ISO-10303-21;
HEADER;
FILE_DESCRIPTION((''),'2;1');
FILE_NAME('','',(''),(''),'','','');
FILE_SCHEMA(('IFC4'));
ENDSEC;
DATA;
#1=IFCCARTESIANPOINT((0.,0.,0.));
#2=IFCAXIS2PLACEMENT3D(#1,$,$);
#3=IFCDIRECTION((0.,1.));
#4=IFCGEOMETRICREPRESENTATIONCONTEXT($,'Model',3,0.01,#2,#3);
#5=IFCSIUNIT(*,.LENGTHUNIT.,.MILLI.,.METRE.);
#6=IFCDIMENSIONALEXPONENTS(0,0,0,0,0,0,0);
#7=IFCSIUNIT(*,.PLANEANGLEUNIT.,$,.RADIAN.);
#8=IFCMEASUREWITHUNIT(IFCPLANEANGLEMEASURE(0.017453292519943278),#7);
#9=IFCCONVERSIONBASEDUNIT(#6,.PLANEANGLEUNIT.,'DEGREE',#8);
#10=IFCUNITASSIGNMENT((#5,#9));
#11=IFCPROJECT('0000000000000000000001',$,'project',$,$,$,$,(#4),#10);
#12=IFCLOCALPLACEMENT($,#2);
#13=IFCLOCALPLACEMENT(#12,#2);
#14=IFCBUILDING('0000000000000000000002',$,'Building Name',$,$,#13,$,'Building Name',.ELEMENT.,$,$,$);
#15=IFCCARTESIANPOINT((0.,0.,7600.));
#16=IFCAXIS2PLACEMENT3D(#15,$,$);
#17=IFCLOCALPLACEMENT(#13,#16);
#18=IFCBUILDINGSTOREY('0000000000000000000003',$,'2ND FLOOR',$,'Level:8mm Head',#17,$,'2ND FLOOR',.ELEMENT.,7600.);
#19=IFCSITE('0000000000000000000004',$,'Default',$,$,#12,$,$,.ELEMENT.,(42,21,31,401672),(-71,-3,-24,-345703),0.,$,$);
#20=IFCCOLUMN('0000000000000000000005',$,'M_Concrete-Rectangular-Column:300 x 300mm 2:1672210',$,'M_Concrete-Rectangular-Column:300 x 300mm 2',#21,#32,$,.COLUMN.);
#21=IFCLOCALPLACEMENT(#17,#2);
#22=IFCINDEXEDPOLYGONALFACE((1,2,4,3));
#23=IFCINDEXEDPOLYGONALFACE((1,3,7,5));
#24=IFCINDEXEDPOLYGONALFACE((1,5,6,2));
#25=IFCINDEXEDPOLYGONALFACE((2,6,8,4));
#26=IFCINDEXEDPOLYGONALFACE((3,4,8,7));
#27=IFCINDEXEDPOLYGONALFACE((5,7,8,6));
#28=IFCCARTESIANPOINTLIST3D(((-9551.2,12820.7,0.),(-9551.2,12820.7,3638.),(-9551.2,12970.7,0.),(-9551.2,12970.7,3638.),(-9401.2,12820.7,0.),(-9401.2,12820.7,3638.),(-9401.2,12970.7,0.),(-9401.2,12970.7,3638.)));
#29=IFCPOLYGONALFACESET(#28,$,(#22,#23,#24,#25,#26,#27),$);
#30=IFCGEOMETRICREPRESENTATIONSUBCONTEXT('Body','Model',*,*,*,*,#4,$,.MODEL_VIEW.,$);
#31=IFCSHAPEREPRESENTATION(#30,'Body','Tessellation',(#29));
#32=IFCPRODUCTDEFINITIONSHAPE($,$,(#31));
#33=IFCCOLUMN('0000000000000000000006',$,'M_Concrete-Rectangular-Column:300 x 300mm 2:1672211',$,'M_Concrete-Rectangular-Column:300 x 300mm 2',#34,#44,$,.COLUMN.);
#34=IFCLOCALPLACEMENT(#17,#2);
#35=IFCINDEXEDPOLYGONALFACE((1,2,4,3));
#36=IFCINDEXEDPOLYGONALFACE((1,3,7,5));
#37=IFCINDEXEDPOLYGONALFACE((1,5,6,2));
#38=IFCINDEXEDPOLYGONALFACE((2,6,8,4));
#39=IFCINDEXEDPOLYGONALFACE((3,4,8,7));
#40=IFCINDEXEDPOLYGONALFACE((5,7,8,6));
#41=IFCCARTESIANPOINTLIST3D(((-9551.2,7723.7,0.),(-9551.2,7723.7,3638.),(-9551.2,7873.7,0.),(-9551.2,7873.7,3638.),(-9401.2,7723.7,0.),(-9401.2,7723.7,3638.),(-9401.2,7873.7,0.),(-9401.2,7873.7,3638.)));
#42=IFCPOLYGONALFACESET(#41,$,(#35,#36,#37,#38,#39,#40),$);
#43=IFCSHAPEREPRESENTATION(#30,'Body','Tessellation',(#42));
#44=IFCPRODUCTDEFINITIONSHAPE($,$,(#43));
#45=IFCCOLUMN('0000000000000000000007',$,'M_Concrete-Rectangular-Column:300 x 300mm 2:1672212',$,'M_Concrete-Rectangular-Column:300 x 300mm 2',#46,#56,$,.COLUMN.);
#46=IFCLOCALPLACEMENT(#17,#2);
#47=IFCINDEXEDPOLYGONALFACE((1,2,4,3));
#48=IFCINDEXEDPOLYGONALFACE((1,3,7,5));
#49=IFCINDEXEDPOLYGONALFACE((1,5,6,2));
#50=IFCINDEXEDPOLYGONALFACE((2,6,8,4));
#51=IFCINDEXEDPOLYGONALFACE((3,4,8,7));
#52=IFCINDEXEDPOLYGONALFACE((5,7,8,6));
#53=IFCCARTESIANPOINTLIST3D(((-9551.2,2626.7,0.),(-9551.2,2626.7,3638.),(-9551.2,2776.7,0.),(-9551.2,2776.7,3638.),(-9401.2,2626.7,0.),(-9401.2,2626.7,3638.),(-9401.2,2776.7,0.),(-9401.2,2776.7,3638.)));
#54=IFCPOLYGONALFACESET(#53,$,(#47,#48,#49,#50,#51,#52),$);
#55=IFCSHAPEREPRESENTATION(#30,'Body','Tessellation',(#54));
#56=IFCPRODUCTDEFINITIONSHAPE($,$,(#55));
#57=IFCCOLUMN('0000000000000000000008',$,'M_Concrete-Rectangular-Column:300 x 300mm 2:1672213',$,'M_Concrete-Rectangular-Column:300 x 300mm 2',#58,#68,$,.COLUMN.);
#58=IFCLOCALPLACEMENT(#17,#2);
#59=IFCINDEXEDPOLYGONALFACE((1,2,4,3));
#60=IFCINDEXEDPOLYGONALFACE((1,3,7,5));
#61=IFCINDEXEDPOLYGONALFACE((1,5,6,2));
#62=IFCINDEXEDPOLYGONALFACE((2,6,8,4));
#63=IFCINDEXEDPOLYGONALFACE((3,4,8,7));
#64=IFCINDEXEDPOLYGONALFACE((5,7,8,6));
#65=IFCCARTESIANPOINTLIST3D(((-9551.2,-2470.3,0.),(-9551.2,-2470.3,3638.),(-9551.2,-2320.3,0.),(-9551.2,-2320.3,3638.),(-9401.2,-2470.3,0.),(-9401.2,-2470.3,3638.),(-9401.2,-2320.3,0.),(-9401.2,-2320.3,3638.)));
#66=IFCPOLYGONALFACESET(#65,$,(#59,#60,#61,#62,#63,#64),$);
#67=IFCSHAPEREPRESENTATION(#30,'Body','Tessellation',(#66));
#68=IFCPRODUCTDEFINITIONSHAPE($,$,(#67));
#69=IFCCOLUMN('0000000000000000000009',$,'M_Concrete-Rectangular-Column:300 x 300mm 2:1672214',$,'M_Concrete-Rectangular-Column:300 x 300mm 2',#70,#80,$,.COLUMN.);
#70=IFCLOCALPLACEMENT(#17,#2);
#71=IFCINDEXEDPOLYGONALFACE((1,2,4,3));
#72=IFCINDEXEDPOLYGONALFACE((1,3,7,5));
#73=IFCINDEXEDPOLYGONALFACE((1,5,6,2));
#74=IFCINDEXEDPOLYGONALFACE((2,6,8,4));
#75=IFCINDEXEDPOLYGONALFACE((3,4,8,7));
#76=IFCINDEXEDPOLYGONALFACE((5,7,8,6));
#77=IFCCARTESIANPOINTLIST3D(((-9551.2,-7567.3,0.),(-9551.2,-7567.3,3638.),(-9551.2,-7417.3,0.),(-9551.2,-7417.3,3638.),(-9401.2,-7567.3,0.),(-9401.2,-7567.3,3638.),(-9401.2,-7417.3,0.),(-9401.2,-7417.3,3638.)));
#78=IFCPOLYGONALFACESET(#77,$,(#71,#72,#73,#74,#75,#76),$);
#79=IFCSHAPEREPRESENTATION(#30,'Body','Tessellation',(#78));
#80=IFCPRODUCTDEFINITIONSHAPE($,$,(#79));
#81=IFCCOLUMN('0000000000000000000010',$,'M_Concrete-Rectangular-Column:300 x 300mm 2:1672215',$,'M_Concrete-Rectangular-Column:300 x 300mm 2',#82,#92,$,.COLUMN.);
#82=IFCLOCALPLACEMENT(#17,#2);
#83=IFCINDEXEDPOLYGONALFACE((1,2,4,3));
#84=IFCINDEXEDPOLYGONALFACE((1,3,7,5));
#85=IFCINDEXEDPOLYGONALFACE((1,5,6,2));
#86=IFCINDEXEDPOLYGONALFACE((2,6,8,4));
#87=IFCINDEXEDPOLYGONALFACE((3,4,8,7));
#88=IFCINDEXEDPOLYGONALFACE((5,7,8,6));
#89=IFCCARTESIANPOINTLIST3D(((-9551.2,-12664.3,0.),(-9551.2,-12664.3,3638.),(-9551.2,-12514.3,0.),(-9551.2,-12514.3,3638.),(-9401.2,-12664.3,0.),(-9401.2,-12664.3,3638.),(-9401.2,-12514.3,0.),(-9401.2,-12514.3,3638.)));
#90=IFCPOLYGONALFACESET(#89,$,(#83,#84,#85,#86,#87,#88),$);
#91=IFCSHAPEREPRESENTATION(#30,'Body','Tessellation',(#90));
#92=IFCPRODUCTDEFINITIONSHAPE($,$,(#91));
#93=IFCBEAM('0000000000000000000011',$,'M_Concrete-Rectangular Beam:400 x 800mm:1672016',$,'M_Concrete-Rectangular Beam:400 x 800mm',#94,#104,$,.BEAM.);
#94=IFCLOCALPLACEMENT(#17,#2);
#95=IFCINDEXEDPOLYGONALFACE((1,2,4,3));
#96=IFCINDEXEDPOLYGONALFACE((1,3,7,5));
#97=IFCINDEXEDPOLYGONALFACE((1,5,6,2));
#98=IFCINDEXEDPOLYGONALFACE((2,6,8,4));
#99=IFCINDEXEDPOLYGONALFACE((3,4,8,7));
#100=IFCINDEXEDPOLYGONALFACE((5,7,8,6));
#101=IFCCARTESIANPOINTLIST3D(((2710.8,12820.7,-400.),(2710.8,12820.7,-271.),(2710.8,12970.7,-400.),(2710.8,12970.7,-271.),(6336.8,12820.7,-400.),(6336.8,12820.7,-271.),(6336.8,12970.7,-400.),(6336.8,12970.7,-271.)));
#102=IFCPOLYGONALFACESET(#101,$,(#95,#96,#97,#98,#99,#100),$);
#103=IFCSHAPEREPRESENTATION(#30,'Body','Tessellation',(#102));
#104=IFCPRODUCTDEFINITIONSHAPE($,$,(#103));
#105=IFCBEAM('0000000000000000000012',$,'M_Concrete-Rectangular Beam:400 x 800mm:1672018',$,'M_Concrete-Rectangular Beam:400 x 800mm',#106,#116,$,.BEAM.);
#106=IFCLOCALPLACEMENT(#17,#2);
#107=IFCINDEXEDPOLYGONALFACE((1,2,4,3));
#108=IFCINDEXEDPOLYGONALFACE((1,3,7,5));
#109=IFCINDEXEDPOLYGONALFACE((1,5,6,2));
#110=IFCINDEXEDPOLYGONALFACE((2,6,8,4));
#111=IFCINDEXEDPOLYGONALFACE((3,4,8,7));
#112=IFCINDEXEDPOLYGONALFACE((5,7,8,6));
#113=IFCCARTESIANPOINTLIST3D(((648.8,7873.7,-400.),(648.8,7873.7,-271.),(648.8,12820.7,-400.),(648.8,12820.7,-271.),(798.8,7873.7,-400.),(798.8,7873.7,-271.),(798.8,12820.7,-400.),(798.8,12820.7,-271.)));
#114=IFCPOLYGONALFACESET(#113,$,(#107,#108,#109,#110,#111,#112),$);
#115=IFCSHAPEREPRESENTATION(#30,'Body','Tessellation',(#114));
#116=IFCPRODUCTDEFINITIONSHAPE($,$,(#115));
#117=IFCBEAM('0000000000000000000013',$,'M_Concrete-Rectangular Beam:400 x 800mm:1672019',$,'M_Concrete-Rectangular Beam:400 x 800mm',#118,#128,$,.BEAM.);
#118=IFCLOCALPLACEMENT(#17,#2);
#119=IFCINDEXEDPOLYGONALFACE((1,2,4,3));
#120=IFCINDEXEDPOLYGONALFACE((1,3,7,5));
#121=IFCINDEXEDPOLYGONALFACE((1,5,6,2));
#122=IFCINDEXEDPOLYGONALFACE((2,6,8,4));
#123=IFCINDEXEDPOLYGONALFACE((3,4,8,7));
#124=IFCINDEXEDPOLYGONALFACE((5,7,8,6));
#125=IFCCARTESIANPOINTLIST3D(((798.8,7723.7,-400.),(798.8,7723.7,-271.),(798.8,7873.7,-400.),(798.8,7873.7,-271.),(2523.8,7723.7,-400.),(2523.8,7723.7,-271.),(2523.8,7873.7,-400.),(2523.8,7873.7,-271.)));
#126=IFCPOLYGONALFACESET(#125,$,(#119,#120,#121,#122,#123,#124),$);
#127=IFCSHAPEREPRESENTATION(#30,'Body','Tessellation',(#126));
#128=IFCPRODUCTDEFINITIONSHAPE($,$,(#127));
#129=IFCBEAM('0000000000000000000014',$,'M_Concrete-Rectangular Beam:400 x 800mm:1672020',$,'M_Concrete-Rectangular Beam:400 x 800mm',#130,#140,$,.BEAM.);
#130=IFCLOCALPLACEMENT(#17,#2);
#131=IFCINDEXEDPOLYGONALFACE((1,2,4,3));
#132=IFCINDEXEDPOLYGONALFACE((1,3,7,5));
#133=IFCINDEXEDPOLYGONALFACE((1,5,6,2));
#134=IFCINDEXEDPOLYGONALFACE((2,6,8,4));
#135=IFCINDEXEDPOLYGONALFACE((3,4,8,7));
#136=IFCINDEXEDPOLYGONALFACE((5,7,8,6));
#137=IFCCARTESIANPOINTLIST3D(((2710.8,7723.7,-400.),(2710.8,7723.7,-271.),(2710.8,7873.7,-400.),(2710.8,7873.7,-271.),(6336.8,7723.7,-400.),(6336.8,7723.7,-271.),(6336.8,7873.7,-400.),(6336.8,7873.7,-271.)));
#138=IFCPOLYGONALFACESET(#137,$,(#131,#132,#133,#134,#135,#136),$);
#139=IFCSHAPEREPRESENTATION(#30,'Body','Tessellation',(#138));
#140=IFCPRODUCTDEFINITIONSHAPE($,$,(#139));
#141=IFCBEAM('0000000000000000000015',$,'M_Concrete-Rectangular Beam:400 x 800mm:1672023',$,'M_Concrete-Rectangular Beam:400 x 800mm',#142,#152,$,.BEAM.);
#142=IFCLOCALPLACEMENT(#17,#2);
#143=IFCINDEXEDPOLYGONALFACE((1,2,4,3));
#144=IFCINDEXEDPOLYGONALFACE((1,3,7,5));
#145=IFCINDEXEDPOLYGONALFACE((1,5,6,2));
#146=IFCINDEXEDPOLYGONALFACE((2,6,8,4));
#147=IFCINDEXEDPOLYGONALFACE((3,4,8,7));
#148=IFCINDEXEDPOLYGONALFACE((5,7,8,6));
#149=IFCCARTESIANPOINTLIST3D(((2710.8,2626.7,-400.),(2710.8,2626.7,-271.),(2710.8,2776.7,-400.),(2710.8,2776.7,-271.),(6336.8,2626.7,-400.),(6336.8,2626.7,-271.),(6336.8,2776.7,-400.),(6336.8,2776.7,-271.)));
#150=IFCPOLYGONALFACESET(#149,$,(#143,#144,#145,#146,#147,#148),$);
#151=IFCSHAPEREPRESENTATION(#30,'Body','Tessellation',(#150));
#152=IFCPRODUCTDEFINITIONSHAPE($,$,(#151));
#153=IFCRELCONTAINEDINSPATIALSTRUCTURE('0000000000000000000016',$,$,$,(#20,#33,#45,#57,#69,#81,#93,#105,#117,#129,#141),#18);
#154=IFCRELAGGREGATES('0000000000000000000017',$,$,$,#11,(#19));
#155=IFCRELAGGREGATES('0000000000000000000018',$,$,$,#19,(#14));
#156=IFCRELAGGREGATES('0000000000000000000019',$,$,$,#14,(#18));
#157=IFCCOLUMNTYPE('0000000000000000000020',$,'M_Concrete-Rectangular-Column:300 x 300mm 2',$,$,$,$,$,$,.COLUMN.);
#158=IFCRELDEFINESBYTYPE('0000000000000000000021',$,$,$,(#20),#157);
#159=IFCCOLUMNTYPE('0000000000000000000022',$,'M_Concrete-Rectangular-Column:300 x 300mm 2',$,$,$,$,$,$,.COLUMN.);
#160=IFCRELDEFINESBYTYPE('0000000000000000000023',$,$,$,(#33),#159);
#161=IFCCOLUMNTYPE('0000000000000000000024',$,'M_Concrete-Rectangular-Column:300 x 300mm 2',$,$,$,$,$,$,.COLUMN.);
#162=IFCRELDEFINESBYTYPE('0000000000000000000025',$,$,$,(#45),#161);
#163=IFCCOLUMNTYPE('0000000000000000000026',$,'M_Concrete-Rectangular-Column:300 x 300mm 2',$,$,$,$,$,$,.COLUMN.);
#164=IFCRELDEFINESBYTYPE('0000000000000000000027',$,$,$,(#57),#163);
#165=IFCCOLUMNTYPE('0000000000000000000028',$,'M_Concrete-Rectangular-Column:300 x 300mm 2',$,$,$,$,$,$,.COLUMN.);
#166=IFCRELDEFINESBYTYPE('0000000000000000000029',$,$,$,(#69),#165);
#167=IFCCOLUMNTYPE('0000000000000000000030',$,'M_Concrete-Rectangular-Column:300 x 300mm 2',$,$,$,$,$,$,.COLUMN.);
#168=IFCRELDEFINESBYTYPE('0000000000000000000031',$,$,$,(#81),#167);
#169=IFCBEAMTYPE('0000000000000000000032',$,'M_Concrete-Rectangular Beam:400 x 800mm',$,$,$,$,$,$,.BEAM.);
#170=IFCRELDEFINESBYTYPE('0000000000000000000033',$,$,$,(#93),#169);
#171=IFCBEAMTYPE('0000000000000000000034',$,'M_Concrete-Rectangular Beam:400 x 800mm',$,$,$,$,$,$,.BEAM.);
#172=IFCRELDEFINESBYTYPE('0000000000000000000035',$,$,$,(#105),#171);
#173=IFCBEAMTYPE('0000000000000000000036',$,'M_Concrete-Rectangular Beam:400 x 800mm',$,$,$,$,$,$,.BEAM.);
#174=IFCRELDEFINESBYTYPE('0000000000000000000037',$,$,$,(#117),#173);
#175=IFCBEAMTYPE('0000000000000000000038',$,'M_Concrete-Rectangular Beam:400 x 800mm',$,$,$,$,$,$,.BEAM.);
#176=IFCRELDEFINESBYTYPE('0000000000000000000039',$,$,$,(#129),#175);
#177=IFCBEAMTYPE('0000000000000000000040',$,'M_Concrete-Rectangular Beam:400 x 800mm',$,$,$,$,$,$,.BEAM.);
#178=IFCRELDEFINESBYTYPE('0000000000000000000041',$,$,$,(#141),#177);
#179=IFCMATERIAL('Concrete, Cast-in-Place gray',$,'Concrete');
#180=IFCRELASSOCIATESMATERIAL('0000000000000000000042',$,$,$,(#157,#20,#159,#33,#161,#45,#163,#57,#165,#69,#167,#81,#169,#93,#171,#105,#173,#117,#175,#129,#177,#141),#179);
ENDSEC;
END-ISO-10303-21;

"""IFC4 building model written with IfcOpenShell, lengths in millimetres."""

from ifc_helpers import new_model, entity, si_unit, converted_unit, direction, frame, origin, place, context, subcontext, project, spatial, indexed_curve, outline, extrude, source, transform, mapped, material, type_object, type_shapes, element, save


model = new_model("IFC4")

# Units and contexts
model_context = context("Model", 3, precision=0.01, world=origin(), true_north=direction((0.0, 1.0)))
body_context = subcontext(model_context, "Body", "Model", "MODEL_VIEW")
ifc_project = project(units=[si_unit("LENGTHUNIT", "METRE", prefix="MILLI"), converted_unit("PLANEANGLEUNIT", "DEGREE", entity("IfcPlaneAngleMeasure", 0.017453292519943278), si_unit("PLANEANGLEUNIT", "RADIAN"), dimensions=[0, 0, 0, 0, 0, 0, 0])], contexts=[model_context])

# Site, building, storey
site_placement = place(None, origin())
site = spatial("IfcSite", under=ifc_project, at=site_placement, Name="Default", CompositionType="ELEMENT", RefLatitude=(42, 21, 31, 401672), RefLongitude=(-71, -3, -24, -345703), RefElevation=0.0)
building_placement = place(site_placement, origin())
building = spatial("IfcBuilding", under=site, at=building_placement, Name="Building Name", LongName="Building Name", CompositionType="ELEMENT")
storey_placement = place(building_placement, frame((0.0, 0.0, 7600.0)))
storey = spatial("IfcBuildingStorey", under=building, at=storey_placement, Name="2ND FLOOR", ObjectType="Level:8mm Head", LongName="2ND FLOOR", CompositionType="ELEMENT", Elevation=7600.0)

# Columns
ifc_material_1 = material(Name="Concrete, Cast-in-Place gray", Category="Concrete")
column_type_1 = type_object("IfcColumnType", Name="M_Concrete-Rectangular-Column:300 x 300mm 2", PredefinedType="COLUMN", material=ifc_material_1)
shared_shape_1 = source(origin(), body_context, "Body", "SweptSolid", [
    extrude(outline(indexed_curve([(-75.0, -75.0), (75.0, -75.0), (75.0, 75.0), (-75.0, 75.0), (-75.0, -75.0)], self_intersect=False)), frame((-9476.2, 12895.7, 7600.0), z_axis=(0.0, 0.0, 1.0), x_axis=(-1.0, 0.0, 0.0)), (0.0, 0.0, 1.0), 3638.0),
])
type_shapes(column_type_1, [shared_shape_1])
column_1_placement = place(storey_placement, frame((0.0, 0.0, -7600.0)))
element("IfcColumn", 1, at=column_1_placement, inside=storey, type_object=column_type_1, material=ifc_material_1, Name="M_Concrete-Rectangular-Column:300 x 300mm 2:1672210", ObjectType="M_Concrete-Rectangular-Column:300 x 300mm 2", PredefinedType="COLUMN", context=body_context, shape_type="MappedRepresentation", body=[
    mapped(shared_shape_1, transform((0.0, 0.0, 0.0), scale=1.0)),
])
column_type_2 = type_object("IfcColumnType", Name="M_Concrete-Rectangular-Column:300 x 300mm 2", PredefinedType="COLUMN", material=ifc_material_1)
shared_shape_2 = source(origin(), body_context, "Body", "SweptSolid", [
    extrude(outline(indexed_curve([(-75.0, -75.0), (75.0, -75.0), (75.0, 75.0), (-75.0, 75.0), (-75.0, -75.0)], self_intersect=False)), frame((-9476.2, 7798.7, 7600.0), z_axis=(0.0, 0.0, 1.0), x_axis=(-1.0, 0.0, 0.0)), (0.0, 0.0, 1.0), 3638.0),
])
type_shapes(column_type_2, [shared_shape_2])
column_2_placement = place(storey_placement, frame((0.0, 0.0, -7600.0)))
element("IfcColumn", 2, at=column_2_placement, inside=storey, type_object=column_type_2, material=ifc_material_1, Name="M_Concrete-Rectangular-Column:300 x 300mm 2:1672211", ObjectType="M_Concrete-Rectangular-Column:300 x 300mm 2", PredefinedType="COLUMN", context=body_context, shape_type="MappedRepresentation", body=[
    mapped(shared_shape_2, transform((0.0, 0.0, 0.0), scale=1.0)),
])
column_type_3 = type_object("IfcColumnType", Name="M_Concrete-Rectangular-Column:300 x 300mm 2", PredefinedType="COLUMN", material=ifc_material_1)
shared_shape_3 = source(origin(), body_context, "Body", "SweptSolid", [
    extrude(outline(indexed_curve([(-75.0, -75.0), (75.0, -75.0), (75.0, 75.0), (-75.0, 75.0), (-75.0, -75.0)], self_intersect=False)), frame((-9476.2, 2701.7, 7600.0), z_axis=(0.0, 0.0, 1.0), x_axis=(-1.0, 0.0, 0.0)), (0.0, 0.0, 1.0), 3638.0),
])
type_shapes(column_type_3, [shared_shape_3])
column_3_placement = place(storey_placement, frame((0.0, 0.0, -7600.0)))
element("IfcColumn", 3, at=column_3_placement, inside=storey, type_object=column_type_3, material=ifc_material_1, Name="M_Concrete-Rectangular-Column:300 x 300mm 2:1672212", ObjectType="M_Concrete-Rectangular-Column:300 x 300mm 2", PredefinedType="COLUMN", context=body_context, shape_type="MappedRepresentation", body=[
    mapped(shared_shape_3, transform((0.0, 0.0, 0.0), scale=1.0)),
])
column_type_4 = type_object("IfcColumnType", Name="M_Concrete-Rectangular-Column:300 x 300mm 2", PredefinedType="COLUMN", material=ifc_material_1)
shared_shape_4 = source(origin(), body_context, "Body", "SweptSolid", [
    extrude(outline(indexed_curve([(-75.0, -75.0), (75.0, -75.0), (75.0, 75.0), (-75.0, 75.0), (-75.0, -75.0)], self_intersect=False)), frame((-9476.2, -2395.3, 7600.0), z_axis=(0.0, 0.0, 1.0), x_axis=(-1.0, 0.0, 0.0)), (0.0, 0.0, 1.0), 3638.0),
])
type_shapes(column_type_4, [shared_shape_4])
column_4_placement = place(storey_placement, frame((0.0, 0.0, -7600.0)))
element("IfcColumn", 4, at=column_4_placement, inside=storey, type_object=column_type_4, material=ifc_material_1, Name="M_Concrete-Rectangular-Column:300 x 300mm 2:1672213", ObjectType="M_Concrete-Rectangular-Column:300 x 300mm 2", PredefinedType="COLUMN", context=body_context, shape_type="MappedRepresentation", body=[
    mapped(shared_shape_4, transform((0.0, 0.0, 0.0), scale=1.0)),
])
column_type_5 = type_object("IfcColumnType", Name="M_Concrete-Rectangular-Column:300 x 300mm 2", PredefinedType="COLUMN", material=ifc_material_1)
shared_shape_5 = source(origin(), body_context, "Body", "SweptSolid", [
    extrude(outline(indexed_curve([(-75.0, -75.0), (75.0, -75.0), (75.0, 75.0), (-75.0, 75.0), (-75.0, -75.0)], self_intersect=False)), frame((-9476.2, -7492.3, 7600.0), z_axis=(0.0, 0.0, 1.0), x_axis=(-1.0, 0.0, 0.0)), (0.0, 0.0, 1.0), 3638.0),
])
type_shapes(column_type_5, [shared_shape_5])
column_5_placement = place(storey_placement, frame((0.0, 0.0, -7600.0)))
element("IfcColumn", 5, at=column_5_placement, inside=storey, type_object=column_type_5, material=ifc_material_1, Name="M_Concrete-Rectangular-Column:300 x 300mm 2:1672214", ObjectType="M_Concrete-Rectangular-Column:300 x 300mm 2", PredefinedType="COLUMN", context=body_context, shape_type="MappedRepresentation", body=[
    mapped(shared_shape_5, transform((0.0, 0.0, 0.0), scale=1.0)),
])
column_type_6 = type_object("IfcColumnType", Name="M_Concrete-Rectangular-Column:300 x 300mm 2", PredefinedType="COLUMN", material=ifc_material_1)
shared_shape_6 = source(origin(), body_context, "Body", "SweptSolid", [
    extrude(outline(indexed_curve([(-75.0, -75.0), (75.0, -75.0), (75.0, 75.0), (-75.0, 75.0), (-75.0, -75.0)], self_intersect=False)), frame((-9476.2, -12589.3, 7600.0), z_axis=(0.0, 0.0, 1.0), x_axis=(-1.0, 0.0, 0.0)), (0.0, 0.0, 1.0), 3638.0),
])
type_shapes(column_type_6, [shared_shape_6])
column_6_placement = place(storey_placement, frame((0.0, 0.0, -7600.0)))
element("IfcColumn", 6, at=column_6_placement, inside=storey, type_object=column_type_6, material=ifc_material_1, Name="M_Concrete-Rectangular-Column:300 x 300mm 2:1672215", ObjectType="M_Concrete-Rectangular-Column:300 x 300mm 2", PredefinedType="COLUMN", context=body_context, shape_type="MappedRepresentation", body=[
    mapped(shared_shape_6, transform((0.0, 0.0, 0.0), scale=1.0)),
])

# Beams
beam_type_1 = type_object("IfcBeamType", Name="M_Concrete-Rectangular Beam:400 x 800mm", PredefinedType="BEAM", material=ifc_material_1)
shared_shape_7 = source(origin(), body_context, "Body", "SweptSolid", [
    extrude(outline(indexed_curve([(-64.5, -75.0), (64.5, -75.0), (64.5, 75.0), (-64.5, 75.0), (-64.5, -75.0)], self_intersect=False)), frame((2710.8, 12895.7, 7264.5), z_axis=(1.0, 0.0, 0.0), x_axis=(0.0, 0.0, -1.0)), (0.0, 0.0, 1.0), 3626.0),
])
type_shapes(beam_type_1, [shared_shape_7])
beam_1_placement = place(storey_placement, frame((0.0, 0.0, -7600.0)))
element("IfcBeam", 7, at=beam_1_placement, inside=storey, type_object=beam_type_1, material=ifc_material_1, Name="M_Concrete-Rectangular Beam:400 x 800mm:1672016", ObjectType="M_Concrete-Rectangular Beam:400 x 800mm", PredefinedType="BEAM", context=body_context, shape_type="MappedRepresentation", body=[
    mapped(shared_shape_7, transform((0.0, 0.0, 0.0), scale=1.0)),
])
beam_type_2 = type_object("IfcBeamType", Name="M_Concrete-Rectangular Beam:400 x 800mm", PredefinedType="BEAM", material=ifc_material_1)
shared_shape_8 = source(origin(), body_context, "Body", "SweptSolid", [
    extrude(outline(indexed_curve([(-75.0, -64.5), (75.0, -64.5), (75.0, 64.5), (-75.0, 64.5), (-75.0, -64.5)], self_intersect=False)), frame((723.8, 12820.7, 7264.5), z_axis=(0.0, -1.0, 0.0), x_axis=(-1.0, 0.0, 0.0)), (0.0, 0.0, 1.0), 4947.0),
])
type_shapes(beam_type_2, [shared_shape_8])
beam_2_placement = place(storey_placement, frame((0.0, 0.0, -7600.0)))
element("IfcBeam", 8, at=beam_2_placement, inside=storey, type_object=beam_type_2, material=ifc_material_1, Name="M_Concrete-Rectangular Beam:400 x 800mm:1672018", ObjectType="M_Concrete-Rectangular Beam:400 x 800mm", PredefinedType="BEAM", context=body_context, shape_type="MappedRepresentation", body=[
    mapped(shared_shape_8, transform((0.0, 0.0, 0.0), scale=1.0)),
])
beam_type_3 = type_object("IfcBeamType", Name="M_Concrete-Rectangular Beam:400 x 800mm", PredefinedType="BEAM", material=ifc_material_1)
shared_shape_9 = source(origin(), body_context, "Body", "SweptSolid", [
    extrude(outline(indexed_curve([(-64.5, -75.0), (64.5, -75.0), (64.5, 75.0), (-64.5, 75.0), (-64.5, -75.0)], self_intersect=False)), frame((798.8, 7798.7, 7264.5), z_axis=(1.0, 0.0, 0.0), x_axis=(0.0, 0.0, -1.0)), (0.0, 0.0, 1.0), 1725.0),
])
type_shapes(beam_type_3, [shared_shape_9])
beam_3_placement = place(storey_placement, frame((0.0, 0.0, -7600.0)))
element("IfcBeam", 9, at=beam_3_placement, inside=storey, type_object=beam_type_3, material=ifc_material_1, Name="M_Concrete-Rectangular Beam:400 x 800mm:1672019", ObjectType="M_Concrete-Rectangular Beam:400 x 800mm", PredefinedType="BEAM", context=body_context, shape_type="MappedRepresentation", body=[
    mapped(shared_shape_9, transform((0.0, 0.0, 0.0), scale=1.0)),
])
beam_type_4 = type_object("IfcBeamType", Name="M_Concrete-Rectangular Beam:400 x 800mm", PredefinedType="BEAM", material=ifc_material_1)
shared_shape_10 = source(origin(), body_context, "Body", "SweptSolid", [
    extrude(outline(indexed_curve([(-64.5, -75.0), (64.5, -75.0), (64.5, 75.0), (-64.5, 75.0), (-64.5, -75.0)], self_intersect=False)), frame((2710.8, 7798.7, 7264.5), z_axis=(1.0, 0.0, 0.0), x_axis=(0.0, 0.0, -1.0)), (0.0, 0.0, 1.0), 3626.0),
])
type_shapes(beam_type_4, [shared_shape_10])
beam_4_placement = place(storey_placement, frame((0.0, 0.0, -7600.0)))
element("IfcBeam", 10, at=beam_4_placement, inside=storey, type_object=beam_type_4, material=ifc_material_1, Name="M_Concrete-Rectangular Beam:400 x 800mm:1672020", ObjectType="M_Concrete-Rectangular Beam:400 x 800mm", PredefinedType="BEAM", context=body_context, shape_type="MappedRepresentation", body=[
    mapped(shared_shape_10, transform((0.0, 0.0, 0.0), scale=1.0)),
])
beam_type_5 = type_object("IfcBeamType", Name="M_Concrete-Rectangular Beam:400 x 800mm", PredefinedType="BEAM", material=ifc_material_1)
shared_shape_11 = source(origin(), body_context, "Body", "SweptSolid", [
    extrude(outline(indexed_curve([(-64.5, -75.0), (64.5, -75.0), (64.5, 75.0), (-64.5, 75.0), (-64.5, -75.0)], self_intersect=False)), frame((6336.8, 2701.7, 7264.5), z_axis=(-1.0, 0.0, 0.0), x_axis=(0.0, 0.0, -1.0)), (0.0, 0.0, 1.0), 3626.0),
])
type_shapes(beam_type_5, [shared_shape_11])
beam_5_placement = place(storey_placement, frame((0.0, 0.0, -7600.0)))
element("IfcBeam", 11, at=beam_5_placement, inside=storey, type_object=beam_type_5, material=ifc_material_1, Name="M_Concrete-Rectangular Beam:400 x 800mm:1672023", ObjectType="M_Concrete-Rectangular Beam:400 x 800mm", PredefinedType="BEAM", context=body_context, shape_type="MappedRepresentation", body=[
    mapped(shared_shape_11, transform((0.0, 0.0, 0.0), scale=1.0)),
])

save(model, "model.ifc")
